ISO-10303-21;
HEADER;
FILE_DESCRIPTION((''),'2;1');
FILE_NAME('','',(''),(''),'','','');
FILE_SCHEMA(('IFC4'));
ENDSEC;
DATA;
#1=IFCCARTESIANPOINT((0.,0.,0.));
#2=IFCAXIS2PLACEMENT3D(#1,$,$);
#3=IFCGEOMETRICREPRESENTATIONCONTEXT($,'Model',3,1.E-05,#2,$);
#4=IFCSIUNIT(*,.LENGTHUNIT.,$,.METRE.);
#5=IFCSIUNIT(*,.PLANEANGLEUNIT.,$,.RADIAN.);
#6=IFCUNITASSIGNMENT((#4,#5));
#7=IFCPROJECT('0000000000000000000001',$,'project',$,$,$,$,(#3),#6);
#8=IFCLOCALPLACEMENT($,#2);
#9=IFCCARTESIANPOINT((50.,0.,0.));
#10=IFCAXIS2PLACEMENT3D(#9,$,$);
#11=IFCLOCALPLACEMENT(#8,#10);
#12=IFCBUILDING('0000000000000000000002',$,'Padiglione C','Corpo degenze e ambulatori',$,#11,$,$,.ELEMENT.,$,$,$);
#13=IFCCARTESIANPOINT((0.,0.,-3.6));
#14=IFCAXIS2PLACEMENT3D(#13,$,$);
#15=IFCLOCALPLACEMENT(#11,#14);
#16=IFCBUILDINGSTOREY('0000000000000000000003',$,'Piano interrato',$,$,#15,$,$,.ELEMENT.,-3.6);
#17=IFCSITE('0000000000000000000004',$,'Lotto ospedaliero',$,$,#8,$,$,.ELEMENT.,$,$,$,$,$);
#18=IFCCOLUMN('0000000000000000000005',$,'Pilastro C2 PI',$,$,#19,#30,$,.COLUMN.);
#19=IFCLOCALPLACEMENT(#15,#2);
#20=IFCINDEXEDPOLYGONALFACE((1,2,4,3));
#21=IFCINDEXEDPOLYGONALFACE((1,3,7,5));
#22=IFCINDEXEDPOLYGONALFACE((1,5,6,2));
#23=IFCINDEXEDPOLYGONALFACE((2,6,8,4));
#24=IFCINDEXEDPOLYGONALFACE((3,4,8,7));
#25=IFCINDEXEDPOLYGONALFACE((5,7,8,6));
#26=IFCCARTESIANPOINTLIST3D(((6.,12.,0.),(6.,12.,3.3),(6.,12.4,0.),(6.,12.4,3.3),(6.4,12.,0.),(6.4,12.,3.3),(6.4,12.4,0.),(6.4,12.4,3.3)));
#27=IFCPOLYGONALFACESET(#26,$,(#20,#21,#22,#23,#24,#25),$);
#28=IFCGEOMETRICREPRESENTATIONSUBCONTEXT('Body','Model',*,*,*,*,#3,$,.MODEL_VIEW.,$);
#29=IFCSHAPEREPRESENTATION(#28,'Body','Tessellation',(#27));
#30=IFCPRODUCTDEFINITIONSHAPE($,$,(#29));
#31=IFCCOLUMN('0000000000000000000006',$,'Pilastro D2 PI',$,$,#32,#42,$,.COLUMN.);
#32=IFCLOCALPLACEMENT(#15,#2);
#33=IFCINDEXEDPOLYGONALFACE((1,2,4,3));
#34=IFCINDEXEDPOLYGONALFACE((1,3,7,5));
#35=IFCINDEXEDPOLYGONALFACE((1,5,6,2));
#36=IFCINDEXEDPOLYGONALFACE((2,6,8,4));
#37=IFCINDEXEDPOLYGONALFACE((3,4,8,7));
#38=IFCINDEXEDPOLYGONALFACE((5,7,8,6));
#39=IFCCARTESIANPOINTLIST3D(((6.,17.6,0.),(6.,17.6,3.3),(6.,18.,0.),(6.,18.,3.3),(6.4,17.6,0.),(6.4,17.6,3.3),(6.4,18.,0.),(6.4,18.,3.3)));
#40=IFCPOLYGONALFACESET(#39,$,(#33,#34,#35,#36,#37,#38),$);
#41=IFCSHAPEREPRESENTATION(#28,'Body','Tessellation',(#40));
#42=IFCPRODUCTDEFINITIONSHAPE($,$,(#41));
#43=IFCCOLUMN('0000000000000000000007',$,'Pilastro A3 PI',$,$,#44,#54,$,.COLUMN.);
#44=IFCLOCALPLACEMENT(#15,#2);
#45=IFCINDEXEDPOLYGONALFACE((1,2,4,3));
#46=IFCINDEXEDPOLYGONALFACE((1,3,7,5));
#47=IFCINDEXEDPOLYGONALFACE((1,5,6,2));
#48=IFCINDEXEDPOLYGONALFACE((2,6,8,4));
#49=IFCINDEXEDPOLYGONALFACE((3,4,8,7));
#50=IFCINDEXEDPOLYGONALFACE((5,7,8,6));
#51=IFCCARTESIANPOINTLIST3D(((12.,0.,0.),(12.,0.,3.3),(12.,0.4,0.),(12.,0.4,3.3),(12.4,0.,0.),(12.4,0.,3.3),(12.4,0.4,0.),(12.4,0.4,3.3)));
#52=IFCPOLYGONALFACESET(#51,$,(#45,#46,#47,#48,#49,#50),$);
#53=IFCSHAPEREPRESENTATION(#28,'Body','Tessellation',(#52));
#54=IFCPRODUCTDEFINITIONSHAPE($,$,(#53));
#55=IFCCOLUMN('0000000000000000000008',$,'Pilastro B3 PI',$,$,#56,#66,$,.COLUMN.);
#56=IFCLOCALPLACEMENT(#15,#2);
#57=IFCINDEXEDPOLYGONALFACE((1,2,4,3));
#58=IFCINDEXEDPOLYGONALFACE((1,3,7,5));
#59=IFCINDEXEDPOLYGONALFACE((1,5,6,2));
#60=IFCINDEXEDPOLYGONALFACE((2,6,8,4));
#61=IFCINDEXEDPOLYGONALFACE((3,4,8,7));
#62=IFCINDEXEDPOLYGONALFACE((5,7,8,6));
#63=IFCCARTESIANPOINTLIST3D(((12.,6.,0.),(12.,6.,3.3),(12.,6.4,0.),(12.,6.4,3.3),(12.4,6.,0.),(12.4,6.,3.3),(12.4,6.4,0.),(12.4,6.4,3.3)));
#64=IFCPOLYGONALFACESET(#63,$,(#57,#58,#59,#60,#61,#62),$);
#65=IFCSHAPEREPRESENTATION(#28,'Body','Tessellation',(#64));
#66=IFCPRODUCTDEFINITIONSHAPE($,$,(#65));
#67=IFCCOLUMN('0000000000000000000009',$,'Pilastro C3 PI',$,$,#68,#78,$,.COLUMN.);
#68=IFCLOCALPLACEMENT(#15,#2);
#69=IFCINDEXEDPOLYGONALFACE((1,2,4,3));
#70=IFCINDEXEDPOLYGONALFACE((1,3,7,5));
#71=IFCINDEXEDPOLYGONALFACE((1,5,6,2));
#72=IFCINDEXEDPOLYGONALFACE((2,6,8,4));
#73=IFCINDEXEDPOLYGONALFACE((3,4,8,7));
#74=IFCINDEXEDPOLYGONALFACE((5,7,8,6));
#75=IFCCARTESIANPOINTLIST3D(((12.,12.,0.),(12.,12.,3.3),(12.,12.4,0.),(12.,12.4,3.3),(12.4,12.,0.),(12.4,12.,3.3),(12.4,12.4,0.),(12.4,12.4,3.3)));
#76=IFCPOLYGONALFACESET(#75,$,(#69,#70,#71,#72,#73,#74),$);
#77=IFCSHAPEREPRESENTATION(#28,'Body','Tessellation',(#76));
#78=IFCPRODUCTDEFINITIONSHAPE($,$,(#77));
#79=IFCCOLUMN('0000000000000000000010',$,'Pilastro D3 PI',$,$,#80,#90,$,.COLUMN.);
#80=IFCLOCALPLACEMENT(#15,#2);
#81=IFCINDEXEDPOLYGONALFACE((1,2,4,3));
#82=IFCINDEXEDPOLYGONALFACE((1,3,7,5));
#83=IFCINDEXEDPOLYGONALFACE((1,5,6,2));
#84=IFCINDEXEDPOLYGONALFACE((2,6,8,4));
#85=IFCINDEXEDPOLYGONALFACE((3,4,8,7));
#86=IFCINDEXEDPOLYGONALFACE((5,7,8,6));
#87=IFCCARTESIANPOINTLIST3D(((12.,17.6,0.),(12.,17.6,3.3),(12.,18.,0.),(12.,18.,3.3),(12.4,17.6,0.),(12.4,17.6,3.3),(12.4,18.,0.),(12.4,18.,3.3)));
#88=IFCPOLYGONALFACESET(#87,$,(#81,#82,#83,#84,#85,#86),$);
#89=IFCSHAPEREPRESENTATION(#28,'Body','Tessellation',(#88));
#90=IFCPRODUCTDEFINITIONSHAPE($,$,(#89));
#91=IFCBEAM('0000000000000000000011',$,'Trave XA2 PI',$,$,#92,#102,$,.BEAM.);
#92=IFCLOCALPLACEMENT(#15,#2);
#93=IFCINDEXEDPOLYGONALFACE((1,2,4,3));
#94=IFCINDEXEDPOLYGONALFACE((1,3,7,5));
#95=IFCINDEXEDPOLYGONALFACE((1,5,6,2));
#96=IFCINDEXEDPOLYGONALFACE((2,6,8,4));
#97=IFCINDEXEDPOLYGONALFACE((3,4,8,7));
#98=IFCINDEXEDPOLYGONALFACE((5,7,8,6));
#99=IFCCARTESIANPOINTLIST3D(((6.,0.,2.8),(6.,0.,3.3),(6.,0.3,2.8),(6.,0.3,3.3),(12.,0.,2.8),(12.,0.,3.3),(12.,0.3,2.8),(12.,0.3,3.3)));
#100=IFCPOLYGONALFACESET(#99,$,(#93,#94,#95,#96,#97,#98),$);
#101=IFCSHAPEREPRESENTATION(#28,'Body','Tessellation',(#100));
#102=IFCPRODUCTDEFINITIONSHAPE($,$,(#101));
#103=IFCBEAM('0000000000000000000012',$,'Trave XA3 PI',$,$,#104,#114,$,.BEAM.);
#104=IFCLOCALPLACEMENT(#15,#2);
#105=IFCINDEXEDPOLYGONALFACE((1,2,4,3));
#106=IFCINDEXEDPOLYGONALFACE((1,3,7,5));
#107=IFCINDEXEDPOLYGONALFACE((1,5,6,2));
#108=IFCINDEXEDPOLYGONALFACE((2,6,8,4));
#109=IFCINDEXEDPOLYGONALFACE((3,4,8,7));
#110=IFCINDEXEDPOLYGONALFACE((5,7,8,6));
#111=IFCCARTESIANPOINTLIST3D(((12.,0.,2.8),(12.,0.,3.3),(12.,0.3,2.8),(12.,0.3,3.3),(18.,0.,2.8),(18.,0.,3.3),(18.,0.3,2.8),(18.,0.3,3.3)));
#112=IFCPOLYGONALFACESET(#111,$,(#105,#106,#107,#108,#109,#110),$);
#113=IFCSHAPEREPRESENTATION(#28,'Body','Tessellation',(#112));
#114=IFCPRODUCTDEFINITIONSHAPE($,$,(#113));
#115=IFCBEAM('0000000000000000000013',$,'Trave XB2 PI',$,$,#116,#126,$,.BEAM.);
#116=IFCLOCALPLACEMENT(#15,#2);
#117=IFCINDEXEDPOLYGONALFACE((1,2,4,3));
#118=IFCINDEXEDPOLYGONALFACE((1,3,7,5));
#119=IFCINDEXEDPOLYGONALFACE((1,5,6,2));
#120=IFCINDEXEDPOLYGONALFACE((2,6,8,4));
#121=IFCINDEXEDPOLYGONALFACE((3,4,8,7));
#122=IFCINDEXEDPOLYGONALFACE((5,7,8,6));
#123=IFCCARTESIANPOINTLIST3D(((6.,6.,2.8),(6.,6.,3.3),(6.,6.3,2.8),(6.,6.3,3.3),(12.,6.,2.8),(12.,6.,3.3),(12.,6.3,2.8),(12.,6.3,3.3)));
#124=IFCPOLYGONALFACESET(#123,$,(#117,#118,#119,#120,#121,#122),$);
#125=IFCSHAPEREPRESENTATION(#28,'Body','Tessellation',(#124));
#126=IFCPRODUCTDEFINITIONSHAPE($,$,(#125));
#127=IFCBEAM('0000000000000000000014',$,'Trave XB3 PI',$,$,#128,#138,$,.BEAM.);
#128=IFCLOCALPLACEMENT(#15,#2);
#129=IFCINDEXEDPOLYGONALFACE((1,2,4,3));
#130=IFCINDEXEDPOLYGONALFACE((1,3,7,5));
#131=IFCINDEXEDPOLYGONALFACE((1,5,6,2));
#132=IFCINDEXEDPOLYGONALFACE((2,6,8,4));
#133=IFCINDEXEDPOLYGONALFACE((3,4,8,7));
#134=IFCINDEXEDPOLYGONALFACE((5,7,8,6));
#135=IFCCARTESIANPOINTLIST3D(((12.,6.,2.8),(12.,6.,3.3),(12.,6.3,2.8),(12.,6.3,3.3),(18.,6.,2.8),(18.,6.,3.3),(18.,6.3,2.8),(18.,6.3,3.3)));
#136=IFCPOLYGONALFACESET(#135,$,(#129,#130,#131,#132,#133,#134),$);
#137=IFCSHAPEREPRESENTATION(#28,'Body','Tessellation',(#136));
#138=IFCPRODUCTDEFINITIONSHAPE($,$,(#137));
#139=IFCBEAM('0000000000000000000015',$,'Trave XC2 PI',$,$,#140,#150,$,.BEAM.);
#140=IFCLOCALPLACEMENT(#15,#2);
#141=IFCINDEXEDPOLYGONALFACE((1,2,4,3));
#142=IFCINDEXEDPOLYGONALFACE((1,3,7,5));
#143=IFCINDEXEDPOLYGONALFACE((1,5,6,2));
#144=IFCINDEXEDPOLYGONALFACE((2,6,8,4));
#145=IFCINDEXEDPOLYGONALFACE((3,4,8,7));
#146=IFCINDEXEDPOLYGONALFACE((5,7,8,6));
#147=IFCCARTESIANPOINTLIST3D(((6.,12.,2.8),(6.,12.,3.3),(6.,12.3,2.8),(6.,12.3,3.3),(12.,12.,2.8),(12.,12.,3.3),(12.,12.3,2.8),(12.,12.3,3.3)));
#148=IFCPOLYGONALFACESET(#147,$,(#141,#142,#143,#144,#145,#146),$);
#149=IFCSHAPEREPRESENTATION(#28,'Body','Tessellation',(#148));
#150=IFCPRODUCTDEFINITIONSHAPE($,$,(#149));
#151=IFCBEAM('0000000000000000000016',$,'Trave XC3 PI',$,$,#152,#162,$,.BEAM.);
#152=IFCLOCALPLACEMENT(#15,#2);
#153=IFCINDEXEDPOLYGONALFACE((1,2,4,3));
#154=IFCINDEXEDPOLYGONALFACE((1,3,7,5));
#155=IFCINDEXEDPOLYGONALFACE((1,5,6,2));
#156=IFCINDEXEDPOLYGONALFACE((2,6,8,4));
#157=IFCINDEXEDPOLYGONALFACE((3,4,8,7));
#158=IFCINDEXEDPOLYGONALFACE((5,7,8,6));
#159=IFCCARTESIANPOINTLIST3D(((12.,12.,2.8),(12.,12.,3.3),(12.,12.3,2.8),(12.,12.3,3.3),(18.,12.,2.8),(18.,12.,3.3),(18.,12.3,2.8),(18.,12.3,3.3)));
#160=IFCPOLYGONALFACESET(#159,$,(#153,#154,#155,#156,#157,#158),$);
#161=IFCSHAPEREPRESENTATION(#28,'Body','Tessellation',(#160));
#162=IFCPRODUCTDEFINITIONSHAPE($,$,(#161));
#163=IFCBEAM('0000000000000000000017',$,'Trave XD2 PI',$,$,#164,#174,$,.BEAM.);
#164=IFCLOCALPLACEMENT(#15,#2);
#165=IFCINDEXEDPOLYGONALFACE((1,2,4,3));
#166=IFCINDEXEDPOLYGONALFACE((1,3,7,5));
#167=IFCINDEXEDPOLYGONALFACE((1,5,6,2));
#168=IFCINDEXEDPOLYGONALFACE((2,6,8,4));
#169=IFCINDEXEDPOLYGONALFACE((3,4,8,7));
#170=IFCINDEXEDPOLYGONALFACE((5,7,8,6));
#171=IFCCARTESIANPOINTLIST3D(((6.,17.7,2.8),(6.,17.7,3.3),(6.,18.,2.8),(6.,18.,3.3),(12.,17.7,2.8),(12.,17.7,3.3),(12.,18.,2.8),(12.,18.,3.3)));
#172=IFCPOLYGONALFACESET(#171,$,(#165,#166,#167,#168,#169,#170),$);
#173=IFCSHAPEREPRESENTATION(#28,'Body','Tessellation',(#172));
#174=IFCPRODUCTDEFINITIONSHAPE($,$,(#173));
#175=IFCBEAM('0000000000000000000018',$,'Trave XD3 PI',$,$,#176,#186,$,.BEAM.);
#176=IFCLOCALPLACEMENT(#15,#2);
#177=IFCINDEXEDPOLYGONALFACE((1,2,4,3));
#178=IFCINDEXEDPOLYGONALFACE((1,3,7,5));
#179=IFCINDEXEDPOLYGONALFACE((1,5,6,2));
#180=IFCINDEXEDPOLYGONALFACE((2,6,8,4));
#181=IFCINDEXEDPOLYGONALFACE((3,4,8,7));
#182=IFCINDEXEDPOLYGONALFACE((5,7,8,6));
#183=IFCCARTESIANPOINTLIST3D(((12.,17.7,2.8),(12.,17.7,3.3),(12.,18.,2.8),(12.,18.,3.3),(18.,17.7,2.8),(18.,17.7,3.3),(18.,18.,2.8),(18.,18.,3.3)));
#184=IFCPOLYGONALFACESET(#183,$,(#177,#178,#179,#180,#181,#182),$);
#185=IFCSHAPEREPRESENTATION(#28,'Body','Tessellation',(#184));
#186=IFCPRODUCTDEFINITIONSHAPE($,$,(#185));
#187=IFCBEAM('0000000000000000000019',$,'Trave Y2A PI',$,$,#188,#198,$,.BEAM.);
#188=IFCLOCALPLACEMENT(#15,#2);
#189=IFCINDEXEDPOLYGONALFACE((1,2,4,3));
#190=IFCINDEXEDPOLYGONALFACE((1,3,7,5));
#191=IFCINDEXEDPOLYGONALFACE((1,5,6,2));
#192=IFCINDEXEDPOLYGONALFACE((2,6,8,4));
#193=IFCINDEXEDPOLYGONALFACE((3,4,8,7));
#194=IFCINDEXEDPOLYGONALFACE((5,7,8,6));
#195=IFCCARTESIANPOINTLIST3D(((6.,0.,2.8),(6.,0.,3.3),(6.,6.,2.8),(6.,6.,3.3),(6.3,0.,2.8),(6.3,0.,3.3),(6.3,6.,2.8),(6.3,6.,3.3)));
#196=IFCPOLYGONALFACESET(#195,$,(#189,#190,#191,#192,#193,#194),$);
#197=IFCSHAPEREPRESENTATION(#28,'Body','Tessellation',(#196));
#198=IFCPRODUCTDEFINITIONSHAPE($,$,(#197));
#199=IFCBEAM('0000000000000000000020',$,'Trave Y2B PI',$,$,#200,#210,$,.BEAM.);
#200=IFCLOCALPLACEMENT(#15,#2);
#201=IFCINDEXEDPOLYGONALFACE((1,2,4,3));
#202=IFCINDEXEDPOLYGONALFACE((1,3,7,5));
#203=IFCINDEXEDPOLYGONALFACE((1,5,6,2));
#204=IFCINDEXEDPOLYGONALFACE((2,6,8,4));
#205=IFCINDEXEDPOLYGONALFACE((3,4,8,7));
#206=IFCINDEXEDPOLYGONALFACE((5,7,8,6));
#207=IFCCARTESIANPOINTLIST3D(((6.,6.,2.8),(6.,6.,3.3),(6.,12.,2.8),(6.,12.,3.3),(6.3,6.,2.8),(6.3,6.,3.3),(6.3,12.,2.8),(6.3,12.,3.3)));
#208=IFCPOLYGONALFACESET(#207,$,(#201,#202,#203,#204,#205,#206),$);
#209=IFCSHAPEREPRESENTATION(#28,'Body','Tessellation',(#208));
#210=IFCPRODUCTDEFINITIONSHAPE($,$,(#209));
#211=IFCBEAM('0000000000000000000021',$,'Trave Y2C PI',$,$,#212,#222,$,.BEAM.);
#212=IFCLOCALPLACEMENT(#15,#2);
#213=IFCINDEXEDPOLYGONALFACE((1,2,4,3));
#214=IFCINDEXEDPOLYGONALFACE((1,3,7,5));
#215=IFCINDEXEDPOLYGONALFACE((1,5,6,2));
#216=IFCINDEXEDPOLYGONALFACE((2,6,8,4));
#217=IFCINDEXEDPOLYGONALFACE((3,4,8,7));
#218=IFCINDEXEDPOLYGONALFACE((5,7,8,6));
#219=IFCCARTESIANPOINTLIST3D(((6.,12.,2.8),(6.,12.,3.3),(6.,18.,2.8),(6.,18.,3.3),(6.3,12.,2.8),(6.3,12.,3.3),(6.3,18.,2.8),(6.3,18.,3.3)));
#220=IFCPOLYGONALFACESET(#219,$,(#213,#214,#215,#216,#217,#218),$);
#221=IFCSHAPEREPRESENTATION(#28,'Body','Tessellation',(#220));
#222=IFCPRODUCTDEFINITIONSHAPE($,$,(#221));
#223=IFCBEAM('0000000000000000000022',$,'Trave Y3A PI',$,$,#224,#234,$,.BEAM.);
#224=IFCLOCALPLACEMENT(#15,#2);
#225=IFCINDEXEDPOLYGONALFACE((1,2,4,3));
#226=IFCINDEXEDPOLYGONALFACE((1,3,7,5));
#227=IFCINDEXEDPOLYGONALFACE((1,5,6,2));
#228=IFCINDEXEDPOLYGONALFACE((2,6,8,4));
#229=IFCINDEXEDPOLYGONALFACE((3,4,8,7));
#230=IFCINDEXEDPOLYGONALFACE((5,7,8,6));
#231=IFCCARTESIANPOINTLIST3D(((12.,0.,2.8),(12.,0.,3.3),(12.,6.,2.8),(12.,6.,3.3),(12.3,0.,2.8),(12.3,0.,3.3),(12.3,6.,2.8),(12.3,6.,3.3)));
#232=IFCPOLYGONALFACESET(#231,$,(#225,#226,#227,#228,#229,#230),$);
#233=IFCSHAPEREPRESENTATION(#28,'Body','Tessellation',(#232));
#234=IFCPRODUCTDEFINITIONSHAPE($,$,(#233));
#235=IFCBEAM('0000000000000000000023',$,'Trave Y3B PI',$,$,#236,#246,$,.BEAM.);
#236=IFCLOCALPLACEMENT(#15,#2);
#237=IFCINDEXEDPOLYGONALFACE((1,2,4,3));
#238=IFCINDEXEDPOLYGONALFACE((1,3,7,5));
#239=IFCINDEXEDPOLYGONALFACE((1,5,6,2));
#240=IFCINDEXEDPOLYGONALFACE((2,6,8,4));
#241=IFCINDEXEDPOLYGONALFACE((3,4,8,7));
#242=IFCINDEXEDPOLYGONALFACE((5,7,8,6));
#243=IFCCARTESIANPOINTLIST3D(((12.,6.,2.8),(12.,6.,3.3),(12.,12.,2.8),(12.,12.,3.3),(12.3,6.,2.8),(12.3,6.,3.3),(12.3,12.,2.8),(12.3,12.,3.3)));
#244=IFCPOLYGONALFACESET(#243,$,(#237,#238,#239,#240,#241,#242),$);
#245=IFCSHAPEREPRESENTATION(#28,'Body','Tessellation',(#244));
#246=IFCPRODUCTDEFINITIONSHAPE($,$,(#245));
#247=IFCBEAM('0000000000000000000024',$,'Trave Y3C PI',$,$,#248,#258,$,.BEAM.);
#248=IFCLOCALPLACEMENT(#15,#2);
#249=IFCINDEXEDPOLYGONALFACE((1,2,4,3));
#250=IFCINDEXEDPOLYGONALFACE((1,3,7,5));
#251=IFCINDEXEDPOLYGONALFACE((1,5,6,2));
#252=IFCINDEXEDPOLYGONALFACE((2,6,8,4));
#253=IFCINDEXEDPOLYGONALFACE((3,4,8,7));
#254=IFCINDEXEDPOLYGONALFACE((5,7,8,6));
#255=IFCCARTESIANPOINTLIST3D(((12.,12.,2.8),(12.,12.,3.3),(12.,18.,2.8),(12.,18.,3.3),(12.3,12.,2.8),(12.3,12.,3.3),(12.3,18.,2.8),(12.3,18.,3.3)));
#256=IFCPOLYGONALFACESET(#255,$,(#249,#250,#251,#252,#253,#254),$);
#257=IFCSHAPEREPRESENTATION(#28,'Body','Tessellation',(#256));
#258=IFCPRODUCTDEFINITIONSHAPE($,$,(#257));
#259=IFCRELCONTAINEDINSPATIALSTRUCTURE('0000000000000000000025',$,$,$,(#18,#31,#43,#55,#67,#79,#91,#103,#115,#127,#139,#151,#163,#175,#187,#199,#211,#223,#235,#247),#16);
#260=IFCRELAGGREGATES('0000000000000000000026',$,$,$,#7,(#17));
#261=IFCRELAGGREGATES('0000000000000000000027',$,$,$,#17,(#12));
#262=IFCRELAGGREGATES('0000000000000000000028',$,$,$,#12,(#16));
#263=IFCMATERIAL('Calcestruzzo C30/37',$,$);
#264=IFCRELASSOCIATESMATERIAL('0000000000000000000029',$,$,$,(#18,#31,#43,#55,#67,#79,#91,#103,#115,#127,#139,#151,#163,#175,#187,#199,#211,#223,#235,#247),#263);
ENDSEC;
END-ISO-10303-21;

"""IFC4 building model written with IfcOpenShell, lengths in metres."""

from ifc_helpers import new_model, si_unit, frame, frame_2d, origin, place, context, subcontext, project, spatial, rectangle, extrude, material, element, save


model = new_model("IFC4")

# Units and contexts
model_context = context("Model", 3, precision=1e-05, world=origin())
body_context = subcontext(model_context, "Body", "Model", "MODEL_VIEW")
ifc_project = project(units=[si_unit("LENGTHUNIT", "METRE"), si_unit("PLANEANGLEUNIT", "RADIAN")], contexts=[model_context])

# Site, building, storey
site_placement = place(None, origin())
site = spatial("IfcSite", under=ifc_project, at=site_placement, Name="Lotto ospedaliero", CompositionType="ELEMENT")
building_placement = place(site_placement, frame((50.0, 0.0, 0.0)))
building = spatial("IfcBuilding", under=site, at=building_placement, Name="Padiglione C", Description="Corpo degenze e ambulatori", CompositionType="ELEMENT")
storey_placement = place(building_placement, frame((0.0, 0.0, -3.6)))
storey = spatial("IfcBuildingStorey", under=building, at=storey_placement, Name="Piano interrato", CompositionType="ELEMENT", Elevation=-3.6)

# Columns
ifc_material_1 = material(Name="Calcestruzzo C30/37")
for number, where, name in (
    (1, (6.0, 12.0, 0.0), "Pilastro C2 PI"),
    (2, (6.0, 17.6, 0.0), "Pilastro D2 PI"),
    (3, (12.0, 0.0, 0.0), "Pilastro A3 PI"),
    (4, (12.0, 6.0, 0.0), "Pilastro B3 PI"),
    (5, (12.0, 12.0, 0.0), "Pilastro C3 PI"),
    (6, (12.0, 17.6, 0.0), "Pilastro D3 PI"),
):
    element("IfcColumn", number, at=place(storey_placement, frame(where)), inside=storey, material=ifc_material_1, Name=name, PredefinedType="COLUMN", context=body_context, shape_type="SweptSolid", body=[
        extrude(rectangle(XDim=0.4, YDim=0.4, at=frame_2d((0.2, 0.2))), origin(), (0.0, 0.0, 1.0), 3.3),
    ])

# Beams
for number, where, name in (
    (7, (6.0, 0.0, 2.8), "Trave XA2 PI"),
    (8, (12.0, 0.0, 2.8), "Trave XA3 PI"),
    (9, (6.0, 6.0, 2.8), "Trave XB2 PI"),
    (10, (12.0, 6.0, 2.8), "Trave XB3 PI"),
    (11, (6.0, 12.0, 2.8), "Trave XC2 PI"),
    (12, (12.0, 12.0, 2.8), "Trave XC3 PI"),
    (13, (6.0, 17.7, 2.8), "Trave XD2 PI"),
    (14, (12.0, 17.7, 2.8), "Trave XD3 PI"),
):
    element("IfcBeam", number, at=place(storey_placement, frame(where)), inside=storey, material=ifc_material_1, Name=name, PredefinedType="BEAM", context=body_context, shape_type="SweptSolid", body=[
        extrude(rectangle(XDim=6.0, YDim=0.3, at=frame_2d((3.0, 0.15))), origin(), (0.0, 0.0, 1.0), 0.5),
    ])
for number, where, name in (
    (15, (6.0, 0.0, 2.8), "Trave Y2A PI"),
    (16, (6.0, 6.0, 2.8), "Trave Y2B PI"),
    (17, (6.0, 12.0, 2.8), "Trave Y2C PI"),
    (18, (12.0, 0.0, 2.8), "Trave Y3A PI"),
    (19, (12.0, 6.0, 2.8), "Trave Y3B PI"),
    (20, (12.0, 12.0, 2.8), "Trave Y3C PI"),
):
    element("IfcBeam", number, at=place(storey_placement, frame(where)), inside=storey, material=ifc_material_1, Name=name, PredefinedType="BEAM", context=body_context, shape_type="SweptSolid", body=[
        extrude(rectangle(XDim=0.3, YDim=6.0, at=frame_2d((0.15, 3.0))), origin(), (0.0, 0.0, 1.0), 0.5),
    ])

save(model, "model.ifc")
